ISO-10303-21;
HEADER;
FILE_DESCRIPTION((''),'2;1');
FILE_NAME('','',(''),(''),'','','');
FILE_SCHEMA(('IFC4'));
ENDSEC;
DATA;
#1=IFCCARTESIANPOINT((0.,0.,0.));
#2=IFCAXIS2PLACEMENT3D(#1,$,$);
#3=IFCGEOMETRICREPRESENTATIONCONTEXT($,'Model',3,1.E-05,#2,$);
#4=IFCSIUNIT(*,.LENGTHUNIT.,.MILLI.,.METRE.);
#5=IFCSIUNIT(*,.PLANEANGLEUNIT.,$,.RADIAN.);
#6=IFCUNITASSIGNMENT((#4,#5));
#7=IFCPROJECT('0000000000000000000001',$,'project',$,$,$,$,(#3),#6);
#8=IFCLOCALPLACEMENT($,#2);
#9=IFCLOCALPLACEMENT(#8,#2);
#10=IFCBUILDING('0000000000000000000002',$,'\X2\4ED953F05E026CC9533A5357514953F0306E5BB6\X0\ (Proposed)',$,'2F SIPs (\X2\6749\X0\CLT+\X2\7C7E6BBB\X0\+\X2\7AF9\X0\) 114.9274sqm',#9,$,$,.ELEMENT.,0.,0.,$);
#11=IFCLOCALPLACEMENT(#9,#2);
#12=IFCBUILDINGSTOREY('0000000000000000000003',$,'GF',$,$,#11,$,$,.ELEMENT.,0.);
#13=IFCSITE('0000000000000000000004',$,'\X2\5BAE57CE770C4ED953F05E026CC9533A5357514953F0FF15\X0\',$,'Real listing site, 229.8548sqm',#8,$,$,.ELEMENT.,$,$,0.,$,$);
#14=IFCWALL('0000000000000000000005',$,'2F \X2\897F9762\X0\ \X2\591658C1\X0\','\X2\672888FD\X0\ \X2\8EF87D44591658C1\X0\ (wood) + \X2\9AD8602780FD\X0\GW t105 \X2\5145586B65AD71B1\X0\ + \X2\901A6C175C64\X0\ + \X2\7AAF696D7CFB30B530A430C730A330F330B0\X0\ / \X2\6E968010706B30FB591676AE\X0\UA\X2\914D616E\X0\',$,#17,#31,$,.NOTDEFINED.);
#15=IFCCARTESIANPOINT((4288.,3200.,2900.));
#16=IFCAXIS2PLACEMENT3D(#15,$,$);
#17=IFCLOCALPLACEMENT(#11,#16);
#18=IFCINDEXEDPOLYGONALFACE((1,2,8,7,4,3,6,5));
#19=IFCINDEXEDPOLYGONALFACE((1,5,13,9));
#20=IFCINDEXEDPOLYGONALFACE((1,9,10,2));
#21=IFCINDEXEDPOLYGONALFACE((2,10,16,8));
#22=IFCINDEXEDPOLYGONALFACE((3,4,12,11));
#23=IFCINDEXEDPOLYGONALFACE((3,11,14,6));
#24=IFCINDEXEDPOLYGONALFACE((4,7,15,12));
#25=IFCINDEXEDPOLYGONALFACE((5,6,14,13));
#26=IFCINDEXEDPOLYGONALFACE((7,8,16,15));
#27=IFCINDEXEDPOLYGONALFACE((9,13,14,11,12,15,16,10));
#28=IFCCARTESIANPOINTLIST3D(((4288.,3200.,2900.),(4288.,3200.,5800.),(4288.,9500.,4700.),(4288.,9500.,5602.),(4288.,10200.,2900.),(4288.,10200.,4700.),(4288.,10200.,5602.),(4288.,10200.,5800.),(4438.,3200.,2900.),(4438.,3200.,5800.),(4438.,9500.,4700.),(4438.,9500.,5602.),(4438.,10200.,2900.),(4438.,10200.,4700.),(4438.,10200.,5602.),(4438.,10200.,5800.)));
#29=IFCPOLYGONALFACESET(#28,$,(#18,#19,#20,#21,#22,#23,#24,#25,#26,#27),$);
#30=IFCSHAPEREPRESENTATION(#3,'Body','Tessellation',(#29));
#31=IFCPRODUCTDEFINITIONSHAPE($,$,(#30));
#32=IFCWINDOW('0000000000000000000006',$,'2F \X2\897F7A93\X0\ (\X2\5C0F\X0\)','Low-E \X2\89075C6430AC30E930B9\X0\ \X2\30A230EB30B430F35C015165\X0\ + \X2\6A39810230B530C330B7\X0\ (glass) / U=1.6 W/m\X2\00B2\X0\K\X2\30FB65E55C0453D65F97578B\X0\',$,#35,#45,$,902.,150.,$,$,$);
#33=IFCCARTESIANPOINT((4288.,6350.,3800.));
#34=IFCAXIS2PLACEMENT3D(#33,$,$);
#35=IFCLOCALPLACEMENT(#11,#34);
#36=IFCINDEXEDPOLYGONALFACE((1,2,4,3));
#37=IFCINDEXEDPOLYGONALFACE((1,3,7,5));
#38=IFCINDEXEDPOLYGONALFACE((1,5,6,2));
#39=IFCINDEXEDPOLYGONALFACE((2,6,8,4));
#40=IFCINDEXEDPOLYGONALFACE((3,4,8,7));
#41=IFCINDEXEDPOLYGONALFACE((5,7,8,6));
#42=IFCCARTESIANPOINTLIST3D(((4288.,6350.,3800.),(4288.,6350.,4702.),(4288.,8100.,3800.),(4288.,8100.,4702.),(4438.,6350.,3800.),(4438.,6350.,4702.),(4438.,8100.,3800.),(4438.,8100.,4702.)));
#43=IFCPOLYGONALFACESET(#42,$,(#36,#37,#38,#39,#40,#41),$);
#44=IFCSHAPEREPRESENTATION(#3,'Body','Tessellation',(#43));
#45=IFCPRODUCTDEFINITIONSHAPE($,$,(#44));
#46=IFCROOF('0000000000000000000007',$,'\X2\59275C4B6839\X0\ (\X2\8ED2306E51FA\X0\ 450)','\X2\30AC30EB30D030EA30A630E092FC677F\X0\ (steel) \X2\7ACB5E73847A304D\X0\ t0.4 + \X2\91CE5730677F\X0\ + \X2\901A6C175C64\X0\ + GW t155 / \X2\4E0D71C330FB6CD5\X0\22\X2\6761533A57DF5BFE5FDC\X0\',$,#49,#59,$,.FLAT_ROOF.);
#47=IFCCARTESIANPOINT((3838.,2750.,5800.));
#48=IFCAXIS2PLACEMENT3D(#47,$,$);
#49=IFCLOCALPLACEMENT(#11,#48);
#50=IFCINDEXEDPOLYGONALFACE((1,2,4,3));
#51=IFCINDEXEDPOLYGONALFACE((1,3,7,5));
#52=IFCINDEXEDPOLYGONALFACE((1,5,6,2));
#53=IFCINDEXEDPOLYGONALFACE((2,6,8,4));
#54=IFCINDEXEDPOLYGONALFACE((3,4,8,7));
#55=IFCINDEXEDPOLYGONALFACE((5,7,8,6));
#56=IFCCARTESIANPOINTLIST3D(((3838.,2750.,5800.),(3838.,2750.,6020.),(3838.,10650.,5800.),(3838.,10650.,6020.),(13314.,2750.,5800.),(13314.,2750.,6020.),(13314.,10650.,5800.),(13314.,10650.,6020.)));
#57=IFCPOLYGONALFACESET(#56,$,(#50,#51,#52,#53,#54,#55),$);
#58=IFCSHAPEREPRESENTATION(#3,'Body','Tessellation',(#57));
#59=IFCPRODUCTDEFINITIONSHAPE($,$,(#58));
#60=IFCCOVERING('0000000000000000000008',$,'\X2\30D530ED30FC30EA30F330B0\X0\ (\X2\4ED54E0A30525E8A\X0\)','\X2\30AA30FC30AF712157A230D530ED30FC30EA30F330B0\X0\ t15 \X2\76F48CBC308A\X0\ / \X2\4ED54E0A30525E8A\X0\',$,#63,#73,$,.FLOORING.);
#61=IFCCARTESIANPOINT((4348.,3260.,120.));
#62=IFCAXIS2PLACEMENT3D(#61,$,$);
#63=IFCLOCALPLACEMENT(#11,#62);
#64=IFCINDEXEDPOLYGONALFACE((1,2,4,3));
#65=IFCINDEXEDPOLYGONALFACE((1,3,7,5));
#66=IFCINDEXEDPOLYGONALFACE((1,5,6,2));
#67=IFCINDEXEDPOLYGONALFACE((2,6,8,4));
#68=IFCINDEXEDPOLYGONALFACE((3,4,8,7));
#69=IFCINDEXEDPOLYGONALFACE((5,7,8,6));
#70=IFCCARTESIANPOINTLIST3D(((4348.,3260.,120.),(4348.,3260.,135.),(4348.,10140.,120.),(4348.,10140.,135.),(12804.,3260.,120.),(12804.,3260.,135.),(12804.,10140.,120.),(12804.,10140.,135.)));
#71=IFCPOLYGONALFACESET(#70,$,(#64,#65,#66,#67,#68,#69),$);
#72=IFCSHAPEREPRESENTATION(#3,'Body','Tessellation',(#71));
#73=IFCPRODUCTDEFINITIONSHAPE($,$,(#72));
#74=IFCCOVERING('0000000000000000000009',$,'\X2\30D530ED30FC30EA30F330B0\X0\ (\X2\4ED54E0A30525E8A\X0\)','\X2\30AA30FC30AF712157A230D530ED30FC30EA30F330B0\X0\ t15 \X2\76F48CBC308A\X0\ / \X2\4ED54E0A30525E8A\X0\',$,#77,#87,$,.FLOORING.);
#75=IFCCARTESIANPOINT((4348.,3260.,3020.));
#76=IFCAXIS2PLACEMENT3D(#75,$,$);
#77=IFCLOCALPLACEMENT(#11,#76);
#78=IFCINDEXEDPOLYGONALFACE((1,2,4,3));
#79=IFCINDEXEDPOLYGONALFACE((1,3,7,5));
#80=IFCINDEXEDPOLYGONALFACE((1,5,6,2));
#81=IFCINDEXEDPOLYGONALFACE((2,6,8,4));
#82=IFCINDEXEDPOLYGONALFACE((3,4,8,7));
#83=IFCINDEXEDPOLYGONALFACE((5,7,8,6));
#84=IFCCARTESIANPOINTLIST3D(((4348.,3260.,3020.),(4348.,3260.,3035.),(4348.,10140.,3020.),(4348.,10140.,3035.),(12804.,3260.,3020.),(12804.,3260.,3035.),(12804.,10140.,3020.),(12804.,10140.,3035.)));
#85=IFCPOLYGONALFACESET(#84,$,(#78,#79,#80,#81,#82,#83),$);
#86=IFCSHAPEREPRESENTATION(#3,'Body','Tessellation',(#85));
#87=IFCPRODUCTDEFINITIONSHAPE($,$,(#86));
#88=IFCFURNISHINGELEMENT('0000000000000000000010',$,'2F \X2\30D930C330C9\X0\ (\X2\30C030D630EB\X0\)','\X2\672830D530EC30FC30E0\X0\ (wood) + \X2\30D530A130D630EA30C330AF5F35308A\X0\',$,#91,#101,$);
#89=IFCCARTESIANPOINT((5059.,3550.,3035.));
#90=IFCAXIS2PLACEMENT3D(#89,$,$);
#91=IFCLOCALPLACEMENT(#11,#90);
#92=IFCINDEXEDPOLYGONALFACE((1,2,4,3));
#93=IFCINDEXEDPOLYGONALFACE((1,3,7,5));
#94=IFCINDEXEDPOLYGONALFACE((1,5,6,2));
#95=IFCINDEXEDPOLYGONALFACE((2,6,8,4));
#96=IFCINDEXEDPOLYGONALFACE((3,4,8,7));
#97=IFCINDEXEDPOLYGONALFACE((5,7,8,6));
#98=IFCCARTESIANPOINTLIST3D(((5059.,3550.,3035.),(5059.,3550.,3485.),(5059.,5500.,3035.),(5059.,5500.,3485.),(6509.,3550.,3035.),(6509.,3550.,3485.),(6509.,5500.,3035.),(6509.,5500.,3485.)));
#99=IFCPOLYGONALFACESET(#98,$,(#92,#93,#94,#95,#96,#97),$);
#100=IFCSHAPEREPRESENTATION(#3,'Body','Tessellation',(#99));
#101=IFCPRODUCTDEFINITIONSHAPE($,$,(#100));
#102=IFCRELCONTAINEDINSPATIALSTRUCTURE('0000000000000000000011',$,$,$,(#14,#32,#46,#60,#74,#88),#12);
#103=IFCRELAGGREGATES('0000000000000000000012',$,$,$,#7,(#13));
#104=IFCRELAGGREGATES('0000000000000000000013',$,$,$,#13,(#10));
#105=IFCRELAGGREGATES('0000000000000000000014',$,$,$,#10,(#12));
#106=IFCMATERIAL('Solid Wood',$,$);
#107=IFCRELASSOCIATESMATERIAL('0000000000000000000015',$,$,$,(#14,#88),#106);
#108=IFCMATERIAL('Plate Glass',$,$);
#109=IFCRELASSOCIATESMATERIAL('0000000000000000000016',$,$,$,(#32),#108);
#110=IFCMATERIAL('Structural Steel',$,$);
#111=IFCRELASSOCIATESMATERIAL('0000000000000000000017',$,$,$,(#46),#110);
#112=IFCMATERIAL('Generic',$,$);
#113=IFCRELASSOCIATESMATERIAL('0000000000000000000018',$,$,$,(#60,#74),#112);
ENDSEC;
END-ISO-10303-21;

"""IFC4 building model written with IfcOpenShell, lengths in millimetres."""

from ifc_helpers import new_model, si_unit, frame, frame_2d, origin, place, context, project, spatial, rectangle, extrude, material, element, fill, save


model = new_model("IFC4")

# Units and contexts
model_context = context("Model", 3, precision=1e-05, world=origin())
ifc_project = project(units=[si_unit("LENGTHUNIT", "METRE", prefix="MILLI"), si_unit("PLANEANGLEUNIT", "RADIAN")], contexts=[model_context])

# Site, building, storey
site_placement = place(None, origin())
site = spatial("IfcSite", under=ifc_project, at=site_placement, Name="宮城県仙台市泉区南光台５", ObjectType="Real listing site, 229.8548sqm", CompositionType="ELEMENT", RefElevation=0.0)
building_placement = place(site_placement, origin())
building = spatial("IfcBuilding", under=site, at=building_placement, Name="仙台市泉区南光台の家 (Proposed)", ObjectType="2F SIPs (杉CLT+籾殻+竹) 114.9274sqm", CompositionType="ELEMENT", ElevationOfRefHeight=0.0, ElevationOfTerrain=0.0)
storey_placement = place(building_placement, origin())
storey = spatial("IfcBuildingStorey", under=building, at=storey_placement, Name="GF", CompositionType="ELEMENT", Elevation=0.0)

# Shared definitions
ifc_material_1 = material(Name="Solid Wood")

# Shared definitions
ifc_material_2 = material(Name="Plate Glass")

# Wall, opening, window
wall_1_placement = place(storey_placement, frame((4288.0, 3200.0, 2900.0)))
wall_1 = element("IfcWall", 1, at=wall_1_placement, inside=storey, material=ifc_material_1, Name="2F 西面 外壁", Description="木製 軸組外壁 (wood) + 高性能GW t105 充填断熱 + 通気層 + 窯業系サイディング / 準耐火・外皮UA配慮", PredefinedType="NOTDEFINED", context=model_context, shape_type="SweptSolid", body=[
    extrude(rectangle(XDim=150.0, YDim=7000.0, at=frame_2d((75.0, 3500.0))), frame((4288.0, 3200.0, 2900.0)), (0.0, 0.0, 1.0), 2900.0),
])
opening_1_placement = place(storey_placement, frame((4288.0, 6350.0, 3800.0)))
opening_1 = element("IfcOpeningElement", 2, at=opening_1_placement, cuts=wall_1, PredefinedType="NOTDEFINED", context=model_context, shape_type="SweptSolid", body=[
    extrude(rectangle(XDim=150.0, YDim=1750.0, at=frame_2d((75.0, 875.0))), frame((4288.0, 6350.0, 3800.0)), (0.0, 0.0, 1.0), 902.0),
])
window_1_placement = place(storey_placement, frame((4288.0, 6350.0, 3800.0)))
window_1 = element("IfcWindow", 3, at=window_1_placement, inside=storey, material=ifc_material_2, Name="2F 西窓 (小)", Description="Low-E 複層ガラス アルゴン封入 + 樹脂サッシ (glass) / U=1.6 W/m²K・日射取得型", OverallHeight=902.0, OverallWidth=150.0, context=model_context, shape_type="SweptSolid", body=[
    extrude(rectangle(XDim=150.0, YDim=1750.0, at=frame_2d((75.0, 875.0))), frame((4288.0, 6350.0, 3800.0)), (0.0, 0.0, 1.0), 902.0),
])
fill(opening_1, window_1)

# Roof
ifc_material_3 = material(Name="Structural Steel")
roof_placement = place(storey_placement, frame((3838.0, 2750.0, 5800.0)))
element("IfcRoof", 4, at=roof_placement, inside=storey, material=ifc_material_3, Name="大屋根 (軒の出 450)", Description="ガルバリウム鋼板 (steel) 立平葺き t0.4 + 野地板 + 通気層 + GW t155 / 不燃・法22条区域対応", PredefinedType="FLAT_ROOF", context=model_context, shape_type="SweptSolid", body=[
    extrude(rectangle(XDim=9476.0, YDim=7900.0, at=frame_2d((4738.0, 3950.0))), frame((3838.0, 2750.0, 5800.0)), (0.0, 0.0, 1.0), 220.0),
])

# Coverings
ifc_material_4 = material(Name="Generic")
covering_1_placement = place(storey_placement, frame((4348.0, 3260.0, 120.0)))
element("IfcCovering", 5, at=covering_1_placement, inside=storey, material=ifc_material_4, Name="フローリング (仕上げ床)", Description="オーク無垢フローリング t15 直貼り / 仕上げ床", PredefinedType="FLOORING", context=model_context, shape_type="SweptSolid", body=[
    extrude(rectangle(XDim=8456.0, YDim=6880.0, at=frame_2d((4228.0, 3440.0))), frame((4348.0, 3260.0, 120.0)), (0.0, 0.0, 1.0), 15.0),
])
covering_2_placement = place(storey_placement, frame((4348.0, 3260.0, 3020.0)))
element("IfcCovering", 6, at=covering_2_placement, inside=storey, material=ifc_material_4, Name="フローリング (仕上げ床)", Description="オーク無垢フローリング t15 直貼り / 仕上げ床", PredefinedType="FLOORING", context=model_context, shape_type="SweptSolid", body=[
    extrude(rectangle(XDim=8456.0, YDim=6880.0, at=frame_2d((4228.0, 3440.0))), frame((4348.0, 3260.0, 3020.0)), (0.0, 0.0, 1.0), 15.0),
])

# Furnishing element
furnishing_placement = place(storey_placement, frame((5059.0, 3550.0, 3035.0)))
element("IfcFurnishingElement", 7, at=furnishing_placement, inside=storey, material=ifc_material_1, Name="2F ベッド (ダブル)", Description="木フレーム (wood) + ファブリック張り", context=model_context, shape_type="SweptSolid", body=[
    extrude(rectangle(XDim=1450.0, YDim=1950.0, at=frame_2d((725.0, 975.0))), frame((5059.0, 3550.0, 3035.0)), (0.0, 0.0, 1.0), 450.0),
])

save(model, "model.ifc")
